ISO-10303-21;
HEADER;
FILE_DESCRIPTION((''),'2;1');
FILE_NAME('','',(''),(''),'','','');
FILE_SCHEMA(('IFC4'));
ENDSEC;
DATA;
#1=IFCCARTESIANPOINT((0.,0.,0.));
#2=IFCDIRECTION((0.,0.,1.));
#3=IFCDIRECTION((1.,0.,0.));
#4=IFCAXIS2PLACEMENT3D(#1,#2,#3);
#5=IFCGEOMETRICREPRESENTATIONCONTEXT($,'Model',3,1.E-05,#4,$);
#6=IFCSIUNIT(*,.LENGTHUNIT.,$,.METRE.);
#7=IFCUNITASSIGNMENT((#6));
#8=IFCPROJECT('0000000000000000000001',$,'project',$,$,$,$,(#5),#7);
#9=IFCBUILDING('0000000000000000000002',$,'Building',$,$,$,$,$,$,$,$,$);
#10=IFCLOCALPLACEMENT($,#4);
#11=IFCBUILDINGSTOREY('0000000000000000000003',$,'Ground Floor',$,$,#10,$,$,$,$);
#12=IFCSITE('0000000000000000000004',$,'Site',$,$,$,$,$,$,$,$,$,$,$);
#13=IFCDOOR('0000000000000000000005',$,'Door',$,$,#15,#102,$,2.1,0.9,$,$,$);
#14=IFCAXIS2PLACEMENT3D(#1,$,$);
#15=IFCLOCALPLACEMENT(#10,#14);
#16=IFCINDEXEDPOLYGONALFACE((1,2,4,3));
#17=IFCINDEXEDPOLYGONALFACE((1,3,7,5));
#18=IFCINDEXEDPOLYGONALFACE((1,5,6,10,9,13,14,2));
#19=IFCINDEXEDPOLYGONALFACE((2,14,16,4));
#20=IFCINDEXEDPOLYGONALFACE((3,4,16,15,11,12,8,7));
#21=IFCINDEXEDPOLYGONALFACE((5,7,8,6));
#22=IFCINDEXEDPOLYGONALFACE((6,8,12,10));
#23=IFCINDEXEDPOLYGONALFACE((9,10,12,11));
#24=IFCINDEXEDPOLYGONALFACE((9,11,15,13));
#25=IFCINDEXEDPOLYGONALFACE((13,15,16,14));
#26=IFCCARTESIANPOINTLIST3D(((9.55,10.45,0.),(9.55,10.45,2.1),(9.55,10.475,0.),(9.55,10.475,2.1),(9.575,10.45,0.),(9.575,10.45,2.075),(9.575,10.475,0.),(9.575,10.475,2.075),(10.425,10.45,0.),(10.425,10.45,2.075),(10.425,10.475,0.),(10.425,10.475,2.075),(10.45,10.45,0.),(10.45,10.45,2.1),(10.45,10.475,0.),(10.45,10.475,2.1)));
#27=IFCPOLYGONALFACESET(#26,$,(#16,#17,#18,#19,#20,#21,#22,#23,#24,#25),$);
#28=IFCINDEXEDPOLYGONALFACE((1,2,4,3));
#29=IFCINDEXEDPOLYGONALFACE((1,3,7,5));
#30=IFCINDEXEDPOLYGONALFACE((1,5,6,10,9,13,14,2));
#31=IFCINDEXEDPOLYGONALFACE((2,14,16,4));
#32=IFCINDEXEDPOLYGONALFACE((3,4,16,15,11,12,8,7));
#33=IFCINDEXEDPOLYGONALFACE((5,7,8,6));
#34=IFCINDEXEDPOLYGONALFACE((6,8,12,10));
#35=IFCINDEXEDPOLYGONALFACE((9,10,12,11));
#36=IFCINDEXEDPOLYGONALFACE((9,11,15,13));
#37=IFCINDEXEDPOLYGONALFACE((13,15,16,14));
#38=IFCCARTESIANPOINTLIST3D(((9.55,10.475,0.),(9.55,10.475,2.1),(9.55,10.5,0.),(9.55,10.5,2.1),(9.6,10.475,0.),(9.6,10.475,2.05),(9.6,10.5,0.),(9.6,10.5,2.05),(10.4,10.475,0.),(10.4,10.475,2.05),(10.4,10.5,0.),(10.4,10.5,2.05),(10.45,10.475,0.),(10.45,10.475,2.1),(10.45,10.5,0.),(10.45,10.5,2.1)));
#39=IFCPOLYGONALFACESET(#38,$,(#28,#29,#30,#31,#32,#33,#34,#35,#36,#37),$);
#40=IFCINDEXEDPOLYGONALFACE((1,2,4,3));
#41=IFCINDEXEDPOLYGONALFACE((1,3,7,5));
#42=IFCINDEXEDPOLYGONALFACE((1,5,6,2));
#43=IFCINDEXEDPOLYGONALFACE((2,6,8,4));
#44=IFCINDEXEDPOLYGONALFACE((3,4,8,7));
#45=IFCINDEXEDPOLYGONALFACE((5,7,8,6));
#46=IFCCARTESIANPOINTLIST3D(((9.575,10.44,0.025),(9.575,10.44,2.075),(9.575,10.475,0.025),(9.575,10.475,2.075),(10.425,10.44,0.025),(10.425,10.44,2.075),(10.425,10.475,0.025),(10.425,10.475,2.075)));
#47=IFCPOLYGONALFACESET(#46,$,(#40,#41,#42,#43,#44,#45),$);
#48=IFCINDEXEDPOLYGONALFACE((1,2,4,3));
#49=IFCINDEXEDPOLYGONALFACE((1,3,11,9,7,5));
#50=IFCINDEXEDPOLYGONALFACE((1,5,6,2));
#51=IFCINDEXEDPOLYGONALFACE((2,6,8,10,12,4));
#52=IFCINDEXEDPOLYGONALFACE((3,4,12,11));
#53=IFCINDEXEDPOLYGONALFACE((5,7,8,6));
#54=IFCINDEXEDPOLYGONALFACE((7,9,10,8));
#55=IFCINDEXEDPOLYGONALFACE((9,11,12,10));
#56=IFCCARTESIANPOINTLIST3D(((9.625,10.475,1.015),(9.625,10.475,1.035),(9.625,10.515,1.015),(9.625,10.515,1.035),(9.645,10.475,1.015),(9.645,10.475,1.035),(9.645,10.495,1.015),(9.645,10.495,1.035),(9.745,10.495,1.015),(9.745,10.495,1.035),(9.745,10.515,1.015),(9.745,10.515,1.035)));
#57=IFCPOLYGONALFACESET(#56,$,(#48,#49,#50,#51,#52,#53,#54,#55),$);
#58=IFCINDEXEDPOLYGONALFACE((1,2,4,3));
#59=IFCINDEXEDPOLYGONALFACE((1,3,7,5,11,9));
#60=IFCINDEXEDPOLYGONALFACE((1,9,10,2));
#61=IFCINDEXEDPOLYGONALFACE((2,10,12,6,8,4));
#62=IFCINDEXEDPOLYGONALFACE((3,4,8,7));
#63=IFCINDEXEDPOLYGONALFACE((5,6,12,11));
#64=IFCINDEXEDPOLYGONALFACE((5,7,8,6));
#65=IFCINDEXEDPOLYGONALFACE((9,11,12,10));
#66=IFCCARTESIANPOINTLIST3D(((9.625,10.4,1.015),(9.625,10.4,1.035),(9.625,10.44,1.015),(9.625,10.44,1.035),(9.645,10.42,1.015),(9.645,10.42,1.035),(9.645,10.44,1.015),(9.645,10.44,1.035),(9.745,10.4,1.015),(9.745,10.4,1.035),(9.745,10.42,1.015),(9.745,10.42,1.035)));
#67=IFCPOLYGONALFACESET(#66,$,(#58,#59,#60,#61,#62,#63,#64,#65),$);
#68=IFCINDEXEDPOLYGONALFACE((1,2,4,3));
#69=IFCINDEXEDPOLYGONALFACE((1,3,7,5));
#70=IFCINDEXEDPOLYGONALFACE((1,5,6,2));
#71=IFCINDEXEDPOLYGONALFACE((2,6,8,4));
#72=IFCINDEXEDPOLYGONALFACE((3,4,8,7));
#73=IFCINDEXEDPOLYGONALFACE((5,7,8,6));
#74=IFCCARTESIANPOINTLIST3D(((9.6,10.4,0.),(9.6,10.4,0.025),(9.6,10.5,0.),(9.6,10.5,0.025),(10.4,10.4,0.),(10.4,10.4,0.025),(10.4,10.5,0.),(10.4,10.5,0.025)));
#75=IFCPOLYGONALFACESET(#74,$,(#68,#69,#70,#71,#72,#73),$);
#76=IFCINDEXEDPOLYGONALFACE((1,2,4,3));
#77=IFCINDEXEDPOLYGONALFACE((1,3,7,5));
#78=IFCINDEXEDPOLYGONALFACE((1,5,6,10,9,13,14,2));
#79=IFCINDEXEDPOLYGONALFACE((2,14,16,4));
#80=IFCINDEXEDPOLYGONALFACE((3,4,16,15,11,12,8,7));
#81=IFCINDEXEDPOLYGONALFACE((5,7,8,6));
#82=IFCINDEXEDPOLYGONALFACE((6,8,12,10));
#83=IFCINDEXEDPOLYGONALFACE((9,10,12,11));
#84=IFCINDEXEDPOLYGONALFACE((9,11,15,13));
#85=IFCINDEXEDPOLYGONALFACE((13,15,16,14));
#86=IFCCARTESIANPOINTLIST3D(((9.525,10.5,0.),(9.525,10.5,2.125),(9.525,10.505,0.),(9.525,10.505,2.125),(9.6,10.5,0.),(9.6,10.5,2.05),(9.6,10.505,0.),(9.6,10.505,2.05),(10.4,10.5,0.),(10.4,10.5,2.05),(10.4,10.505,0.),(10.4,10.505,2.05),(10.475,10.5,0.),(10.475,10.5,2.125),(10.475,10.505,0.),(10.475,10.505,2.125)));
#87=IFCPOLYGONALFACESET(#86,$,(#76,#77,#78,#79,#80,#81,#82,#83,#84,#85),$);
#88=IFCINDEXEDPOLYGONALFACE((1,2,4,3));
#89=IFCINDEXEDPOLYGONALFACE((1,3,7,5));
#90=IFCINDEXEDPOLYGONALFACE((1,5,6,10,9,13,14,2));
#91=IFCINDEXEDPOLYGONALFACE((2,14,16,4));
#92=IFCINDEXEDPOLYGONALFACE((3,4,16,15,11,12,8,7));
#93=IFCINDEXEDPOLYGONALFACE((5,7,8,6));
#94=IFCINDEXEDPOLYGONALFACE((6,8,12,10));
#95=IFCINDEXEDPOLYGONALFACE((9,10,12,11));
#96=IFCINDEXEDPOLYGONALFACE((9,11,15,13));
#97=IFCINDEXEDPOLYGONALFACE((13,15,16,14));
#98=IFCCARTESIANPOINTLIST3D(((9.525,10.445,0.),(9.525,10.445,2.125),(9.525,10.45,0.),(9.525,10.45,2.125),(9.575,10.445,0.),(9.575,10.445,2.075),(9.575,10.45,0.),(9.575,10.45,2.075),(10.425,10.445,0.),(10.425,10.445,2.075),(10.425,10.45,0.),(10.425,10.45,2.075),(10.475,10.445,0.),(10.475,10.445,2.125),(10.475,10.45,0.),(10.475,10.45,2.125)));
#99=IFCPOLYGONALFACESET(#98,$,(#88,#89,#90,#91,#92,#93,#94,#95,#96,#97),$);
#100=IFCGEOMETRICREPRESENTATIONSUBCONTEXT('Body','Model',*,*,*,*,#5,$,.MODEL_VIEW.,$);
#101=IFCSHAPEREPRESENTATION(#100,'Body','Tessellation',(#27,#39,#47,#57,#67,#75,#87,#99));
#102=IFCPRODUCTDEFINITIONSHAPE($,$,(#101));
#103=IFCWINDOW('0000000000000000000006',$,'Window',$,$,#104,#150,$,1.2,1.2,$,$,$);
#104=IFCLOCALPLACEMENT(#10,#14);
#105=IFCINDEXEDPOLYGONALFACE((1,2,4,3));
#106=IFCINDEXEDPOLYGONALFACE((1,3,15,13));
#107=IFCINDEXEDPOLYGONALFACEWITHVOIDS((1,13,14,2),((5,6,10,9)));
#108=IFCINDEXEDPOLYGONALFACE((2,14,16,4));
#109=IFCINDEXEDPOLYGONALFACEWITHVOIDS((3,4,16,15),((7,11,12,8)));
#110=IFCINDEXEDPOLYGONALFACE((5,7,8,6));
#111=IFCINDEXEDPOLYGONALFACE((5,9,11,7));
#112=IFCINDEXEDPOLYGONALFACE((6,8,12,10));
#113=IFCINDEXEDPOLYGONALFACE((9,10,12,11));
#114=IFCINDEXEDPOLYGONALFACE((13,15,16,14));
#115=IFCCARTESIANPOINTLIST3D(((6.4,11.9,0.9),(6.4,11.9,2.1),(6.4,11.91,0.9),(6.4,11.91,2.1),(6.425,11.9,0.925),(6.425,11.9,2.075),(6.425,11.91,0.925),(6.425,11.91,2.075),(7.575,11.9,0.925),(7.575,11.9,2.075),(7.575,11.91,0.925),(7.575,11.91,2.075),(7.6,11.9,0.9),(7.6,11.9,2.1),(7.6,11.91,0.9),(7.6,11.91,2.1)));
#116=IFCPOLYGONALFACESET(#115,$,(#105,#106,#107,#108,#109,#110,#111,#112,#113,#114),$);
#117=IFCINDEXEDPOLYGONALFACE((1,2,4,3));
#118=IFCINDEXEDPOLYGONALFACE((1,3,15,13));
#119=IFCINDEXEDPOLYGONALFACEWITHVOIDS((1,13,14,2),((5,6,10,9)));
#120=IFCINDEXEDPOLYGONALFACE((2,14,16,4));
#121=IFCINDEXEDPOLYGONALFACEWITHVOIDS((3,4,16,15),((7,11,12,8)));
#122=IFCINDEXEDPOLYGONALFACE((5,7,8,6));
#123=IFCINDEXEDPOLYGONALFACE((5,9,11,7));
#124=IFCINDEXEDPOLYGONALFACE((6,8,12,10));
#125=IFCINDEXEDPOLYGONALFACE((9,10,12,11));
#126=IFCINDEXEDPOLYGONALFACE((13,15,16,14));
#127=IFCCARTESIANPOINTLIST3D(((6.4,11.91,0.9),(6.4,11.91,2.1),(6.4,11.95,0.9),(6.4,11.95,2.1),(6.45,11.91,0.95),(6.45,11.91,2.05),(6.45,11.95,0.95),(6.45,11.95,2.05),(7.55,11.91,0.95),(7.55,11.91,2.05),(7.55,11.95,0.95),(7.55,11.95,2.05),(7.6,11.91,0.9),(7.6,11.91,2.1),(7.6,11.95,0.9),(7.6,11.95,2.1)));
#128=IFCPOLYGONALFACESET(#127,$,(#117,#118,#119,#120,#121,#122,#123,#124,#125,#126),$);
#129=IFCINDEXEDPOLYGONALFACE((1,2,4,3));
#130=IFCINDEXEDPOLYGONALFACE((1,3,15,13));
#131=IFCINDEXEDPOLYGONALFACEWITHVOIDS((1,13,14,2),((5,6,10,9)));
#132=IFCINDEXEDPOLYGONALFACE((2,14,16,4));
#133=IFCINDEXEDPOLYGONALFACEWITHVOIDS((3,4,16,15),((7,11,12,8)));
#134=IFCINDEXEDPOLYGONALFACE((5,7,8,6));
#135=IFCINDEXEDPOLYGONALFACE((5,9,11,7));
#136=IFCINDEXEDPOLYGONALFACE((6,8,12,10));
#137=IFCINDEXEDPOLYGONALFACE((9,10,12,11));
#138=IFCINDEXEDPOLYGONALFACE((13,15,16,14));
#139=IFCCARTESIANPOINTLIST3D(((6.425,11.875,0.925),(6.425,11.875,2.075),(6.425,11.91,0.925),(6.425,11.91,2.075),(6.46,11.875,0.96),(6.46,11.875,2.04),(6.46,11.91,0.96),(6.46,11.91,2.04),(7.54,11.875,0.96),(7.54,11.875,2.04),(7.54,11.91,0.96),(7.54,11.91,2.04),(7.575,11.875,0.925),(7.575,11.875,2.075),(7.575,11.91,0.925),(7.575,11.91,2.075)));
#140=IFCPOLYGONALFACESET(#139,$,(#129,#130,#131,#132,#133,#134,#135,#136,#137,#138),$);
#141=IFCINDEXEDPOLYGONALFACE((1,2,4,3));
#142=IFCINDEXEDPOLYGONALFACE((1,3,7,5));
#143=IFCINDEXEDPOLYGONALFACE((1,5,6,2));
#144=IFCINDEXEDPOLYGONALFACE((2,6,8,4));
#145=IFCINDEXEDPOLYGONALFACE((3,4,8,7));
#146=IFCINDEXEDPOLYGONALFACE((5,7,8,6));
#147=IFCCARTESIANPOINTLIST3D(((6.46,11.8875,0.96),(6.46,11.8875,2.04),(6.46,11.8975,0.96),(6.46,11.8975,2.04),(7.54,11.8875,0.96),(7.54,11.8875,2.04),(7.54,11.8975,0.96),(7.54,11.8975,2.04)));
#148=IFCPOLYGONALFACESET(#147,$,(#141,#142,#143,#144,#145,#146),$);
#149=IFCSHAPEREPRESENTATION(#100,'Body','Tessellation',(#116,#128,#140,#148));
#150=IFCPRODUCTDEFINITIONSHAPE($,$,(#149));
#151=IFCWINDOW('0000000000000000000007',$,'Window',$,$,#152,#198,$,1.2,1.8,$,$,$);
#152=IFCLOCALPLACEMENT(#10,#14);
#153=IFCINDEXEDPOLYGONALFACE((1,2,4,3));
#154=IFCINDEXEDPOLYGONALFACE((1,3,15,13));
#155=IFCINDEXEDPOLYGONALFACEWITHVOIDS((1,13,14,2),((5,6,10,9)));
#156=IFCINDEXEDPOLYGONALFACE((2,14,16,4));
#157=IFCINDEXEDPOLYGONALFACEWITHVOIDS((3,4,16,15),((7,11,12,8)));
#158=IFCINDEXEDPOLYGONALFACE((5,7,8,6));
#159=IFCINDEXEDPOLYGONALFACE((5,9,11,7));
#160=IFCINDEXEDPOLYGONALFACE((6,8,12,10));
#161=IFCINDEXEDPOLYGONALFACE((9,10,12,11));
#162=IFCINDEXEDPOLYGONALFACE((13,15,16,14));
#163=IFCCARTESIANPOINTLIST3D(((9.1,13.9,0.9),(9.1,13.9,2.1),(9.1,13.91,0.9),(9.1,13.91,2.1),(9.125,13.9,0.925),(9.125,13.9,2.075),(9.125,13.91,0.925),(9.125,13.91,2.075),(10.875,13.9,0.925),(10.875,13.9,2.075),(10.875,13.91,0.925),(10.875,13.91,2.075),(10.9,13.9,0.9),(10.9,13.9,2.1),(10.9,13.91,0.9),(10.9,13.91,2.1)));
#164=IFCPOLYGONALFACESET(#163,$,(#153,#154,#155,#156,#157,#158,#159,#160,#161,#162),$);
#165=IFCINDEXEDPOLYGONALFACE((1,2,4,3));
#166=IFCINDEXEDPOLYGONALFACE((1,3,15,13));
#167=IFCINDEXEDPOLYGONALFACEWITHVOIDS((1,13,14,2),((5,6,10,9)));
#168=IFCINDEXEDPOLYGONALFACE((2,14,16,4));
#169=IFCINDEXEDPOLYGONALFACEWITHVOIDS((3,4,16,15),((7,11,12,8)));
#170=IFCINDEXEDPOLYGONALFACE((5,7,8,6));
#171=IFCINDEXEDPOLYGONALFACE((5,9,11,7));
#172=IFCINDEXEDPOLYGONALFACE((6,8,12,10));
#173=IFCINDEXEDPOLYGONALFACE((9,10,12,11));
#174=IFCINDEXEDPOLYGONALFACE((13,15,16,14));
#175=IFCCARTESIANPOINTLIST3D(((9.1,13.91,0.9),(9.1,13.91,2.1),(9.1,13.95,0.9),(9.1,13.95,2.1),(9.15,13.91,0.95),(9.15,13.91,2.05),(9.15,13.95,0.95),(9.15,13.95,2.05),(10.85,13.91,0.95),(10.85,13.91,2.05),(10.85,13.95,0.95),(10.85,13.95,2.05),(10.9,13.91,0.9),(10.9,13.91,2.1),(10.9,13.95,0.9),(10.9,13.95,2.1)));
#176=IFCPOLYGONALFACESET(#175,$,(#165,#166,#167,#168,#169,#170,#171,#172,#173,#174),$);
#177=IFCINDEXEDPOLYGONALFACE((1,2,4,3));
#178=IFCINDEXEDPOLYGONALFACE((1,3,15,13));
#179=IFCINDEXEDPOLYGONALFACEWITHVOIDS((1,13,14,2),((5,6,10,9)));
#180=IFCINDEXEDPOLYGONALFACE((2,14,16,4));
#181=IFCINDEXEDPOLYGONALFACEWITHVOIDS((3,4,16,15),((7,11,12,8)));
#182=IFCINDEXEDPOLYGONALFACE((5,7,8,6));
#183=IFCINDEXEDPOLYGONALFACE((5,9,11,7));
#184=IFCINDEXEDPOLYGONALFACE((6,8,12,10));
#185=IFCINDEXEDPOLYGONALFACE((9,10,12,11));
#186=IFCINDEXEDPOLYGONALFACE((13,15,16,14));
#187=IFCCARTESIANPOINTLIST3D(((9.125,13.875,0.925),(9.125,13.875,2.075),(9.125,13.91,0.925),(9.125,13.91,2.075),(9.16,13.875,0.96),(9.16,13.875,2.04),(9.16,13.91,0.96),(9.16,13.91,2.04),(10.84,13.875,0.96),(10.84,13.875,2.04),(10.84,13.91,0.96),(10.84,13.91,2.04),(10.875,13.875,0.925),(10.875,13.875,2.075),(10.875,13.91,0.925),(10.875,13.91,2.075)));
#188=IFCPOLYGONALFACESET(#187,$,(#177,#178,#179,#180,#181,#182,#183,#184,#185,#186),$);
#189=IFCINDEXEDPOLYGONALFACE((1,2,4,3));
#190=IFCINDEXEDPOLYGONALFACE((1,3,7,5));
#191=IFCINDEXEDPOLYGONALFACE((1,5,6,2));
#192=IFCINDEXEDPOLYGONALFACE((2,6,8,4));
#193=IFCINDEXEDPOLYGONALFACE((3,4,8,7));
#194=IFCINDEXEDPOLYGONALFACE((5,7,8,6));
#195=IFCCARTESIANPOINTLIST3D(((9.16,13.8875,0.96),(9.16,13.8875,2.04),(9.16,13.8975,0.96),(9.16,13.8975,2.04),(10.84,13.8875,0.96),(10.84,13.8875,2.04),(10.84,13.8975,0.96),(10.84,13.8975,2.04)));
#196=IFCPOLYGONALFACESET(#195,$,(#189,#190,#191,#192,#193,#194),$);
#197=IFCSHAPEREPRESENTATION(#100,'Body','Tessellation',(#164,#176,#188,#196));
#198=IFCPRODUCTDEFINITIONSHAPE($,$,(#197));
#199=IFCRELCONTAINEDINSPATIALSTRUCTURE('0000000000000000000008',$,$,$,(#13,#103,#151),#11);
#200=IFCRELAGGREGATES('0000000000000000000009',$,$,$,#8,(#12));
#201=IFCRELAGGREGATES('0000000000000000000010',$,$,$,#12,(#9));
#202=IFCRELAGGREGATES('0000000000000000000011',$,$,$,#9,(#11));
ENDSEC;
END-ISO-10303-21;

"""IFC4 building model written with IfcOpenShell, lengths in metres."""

from ifc_helpers import new_model, si_unit, frame, origin_with_axes, place, context, subcontext, project, spatial, line, indexed_curve, outline, extrude, element, save


model = new_model("IFC4")

# Units and contexts
model_context = context("Model", 3, precision=1e-05, world=origin_with_axes())
body_context = subcontext(model_context, "Body", "Model", "MODEL_VIEW")
ifc_project = project(units=[si_unit("LENGTHUNIT", "METRE")], contexts=[model_context])

# Site, building, storey
site = spatial("IfcSite", under=ifc_project, Name="Site")
building = spatial("IfcBuilding", under=site, Name="Building")
storey_placement = place(None, origin_with_axes())
storey = spatial("IfcBuildingStorey", under=building, at=storey_placement, Name="Ground Floor")

# Door
door_1_placement = place(storey_placement, frame((10.45, 10.5, 0.0), z_axis=(0.0, 0.0, 1.0), x_axis=(-1.0, 0.0, 0.0)))
element("IfcDoor", 1, at=door_1_placement, inside=storey, Name="Door", OverallHeight=2.1, OverallWidth=0.9, context=body_context, shape_type="SweptSolid", body=[
    extrude(outline(indexed_curve([(0.0, 0.0), (0.0, 2.1), (0.9, 2.1), (0.9, 0.0), (0.875, 0.0), (0.875, 2.075), (0.025, 2.075), (0.025, 0.0)], segments=[line(1, 2, 3, 4, 5, 6, 7, 8, 1)])), frame((0.0, 0.025, 0.0), z_axis=(0.0, -1.0, 0.0), x_axis=(1.0, 0.0, 0.0)), (0.0, 0.0, -1.0), 0.025),
    extrude(outline(indexed_curve([(0.0, 0.0), (0.0, 2.1), (0.9, 2.1), (0.9, 0.0), (0.85, 0.0), (0.85, 2.05), (0.05, 2.05), (0.05, 0.0)], segments=[line(1, 2, 3, 4, 5, 6, 7, 8, 1)])), frame((0.0, 0.0, 0.0), z_axis=(0.0, -1.0, 0.0), x_axis=(1.0, 0.0, 0.0)), (0.0, 0.0, -1.0), 0.025),
    extrude(outline(indexed_curve([(0.0, 0.0), (0.85, 0.0), (0.85, 0.035), (0.0, 0.035)], segments=[line(1, 2, 3, 4, 1)])), frame((0.025, 0.025, 0.025), z_axis=(0.0, 0.0, 1.0), x_axis=(1.0, 0.0, 0.0)), (0.0, 0.0, 1.0), 2.05),
    extrude(outline(indexed_curve([(0.0, 0.0), (0.0, -0.04), (-0.12, -0.04), (-0.12, -0.02), (-0.02, -0.02), (-0.02, 0.0)], segments=[line(1, 2, 3, 4, 5, 6, 1)])), frame((0.825, 0.025, 1.015), z_axis=(0.0, 0.0, 1.0), x_axis=(1.0, 0.0, 0.0)), (0.0, 0.0, 1.0), 0.02),
    extrude(outline(indexed_curve([(0.0, 0.0), (0.0, 0.04), (-0.12, 0.04), (-0.12, 0.02), (-0.02, 0.02), (-0.02, 0.0)], segments=[line(1, 2, 3, 4, 5, 6, 1)])), frame((0.825, 0.06, 1.015), z_axis=(0.0, 0.0, 1.0), x_axis=(1.0, 0.0, 0.0)), (0.0, 0.0, 1.0), 0.02),
    extrude(outline(indexed_curve([(0.0, 0.0), (0.8, 0.0), (0.8, 0.1), (0.0, 0.1)], segments=[line(1, 2, 3, 4, 1)])), frame((0.05, 0.0, 0.0), z_axis=(0.0, 0.0, 1.0), x_axis=(1.0, 0.0, 0.0)), (0.0, 0.0, 1.0), 0.025),
    extrude(outline(indexed_curve([(0.0, 0.0), (0.0, 2.125), (0.95, 2.125), (0.95, 0.0), (0.875, 0.0), (0.875, 2.05), (0.075, 2.05), (0.075, 0.0)], segments=[line(1, 2, 3, 4, 5, 6, 7, 8, 1)])), frame((-0.025, -0.005, 0.0), z_axis=(0.0, -1.0, 0.0), x_axis=(1.0, 0.0, 0.0)), (0.0, 0.0, -1.0), 0.005),
    extrude(outline(indexed_curve([(0.0, 0.0), (0.0, 2.125), (0.95, 2.125), (0.95, 0.0), (0.9, 0.0), (0.9, 2.075), (0.05, 2.075), (0.05, 0.0)], segments=[line(1, 2, 3, 4, 5, 6, 7, 8, 1)])), frame((-0.025, 0.05, 0.0), z_axis=(0.0, -1.0, 0.0), x_axis=(1.0, 0.0, 0.0)), (0.0, 0.0, -1.0), 0.005),
])

# Windows
window_1_placement = place(storey_placement, frame((7.6, 12.0, 0.9), z_axis=(0.0, 0.0, 1.0), x_axis=(-1.0, 0.0, 0.0)))
element("IfcWindow", 2, at=window_1_placement, inside=storey, Name="Window", OverallHeight=1.2, OverallWidth=1.2, context=body_context, shape_type="SweptSolid", body=[
    extrude(outline(indexed_curve([(0.0, 0.0), (1.2, 0.0), (1.2, 1.2), (0.0, 1.2)], segments=[line(1, 2, 3, 4, 1)]), holes=[indexed_curve([(0.025, 0.025), (1.175, 0.025), (1.175, 1.175), (0.025, 1.175)], segments=[line(1, 2, 3, 4, 1)])]), frame((0.0, 0.09, 0.0), z_axis=(0.0, -1.0, 0.0), x_axis=(1.0, 0.0, 0.0)), (0.0, 0.0, -1.0), 0.01),
    extrude(outline(indexed_curve([(0.0, 0.0), (1.2, 0.0), (1.2, 1.2), (0.0, 1.2)], segments=[line(1, 2, 3, 4, 1)]), holes=[indexed_curve([(0.05, 0.05), (1.15, 0.05), (1.15, 1.15), (0.05, 1.15)], segments=[line(1, 2, 3, 4, 1)])]), frame((0.0, 0.05, 0.0), z_axis=(0.0, -1.0, 0.0), x_axis=(1.0, 0.0, 0.0)), (0.0, 0.0, -1.0), 0.04),
    extrude(outline(indexed_curve([(0.0, 0.0), (1.15, 0.0), (1.15, 1.15), (0.0, 1.15)], segments=[line(1, 2, 3, 4, 1)]), holes=[indexed_curve([(0.035, 0.035), (1.115, 0.035), (1.115, 1.115), (0.035, 1.115)], segments=[line(1, 2, 3, 4, 1)])]), frame((0.025, 0.09, 0.025), z_axis=(0.0, -1.0, 0.0), x_axis=(1.0, 0.0, 0.0)), (0.0, 0.0, -1.0), 0.035),
    extrude(outline(indexed_curve([(0.035, 0.035), (1.115, 0.035), (1.115, 1.115), (0.035, 1.115)], segments=[line(1, 2, 3, 4, 1)])), frame((0.025, 0.1025, 0.025), z_axis=(0.0, -1.0, 0.0), x_axis=(1.0, 0.0, 0.0)), (0.0, 0.0, -1.0), 0.01),
])
window_2_placement = place(storey_placement, frame((10.9, 14.0, 0.9), z_axis=(0.0, 0.0, 1.0), x_axis=(-1.0, 0.0, 0.0)))
element("IfcWindow", 3, at=window_2_placement, inside=storey, Name="Window", OverallHeight=1.2, OverallWidth=1.8, context=body_context, shape_type="SweptSolid", body=[
    extrude(outline(indexed_curve([(0.0, 0.0), (1.8, 0.0), (1.8, 1.2), (0.0, 1.2)], segments=[line(1, 2, 3, 4, 1)]), holes=[indexed_curve([(0.025, 0.025), (1.775, 0.025), (1.775, 1.175), (0.025, 1.175)], segments=[line(1, 2, 3, 4, 1)])]), frame((0.0, 0.09, 0.0), z_axis=(0.0, -1.0, 0.0), x_axis=(1.0, 0.0, 0.0)), (0.0, 0.0, -1.0), 0.01),
    extrude(outline(indexed_curve([(0.0, 0.0), (1.8, 0.0), (1.8, 1.2), (0.0, 1.2)], segments=[line(1, 2, 3, 4, 1)]), holes=[indexed_curve([(0.05, 0.05), (1.75, 0.05), (1.75, 1.15), (0.05, 1.15)], segments=[line(1, 2, 3, 4, 1)])]), frame((0.0, 0.05, 0.0), z_axis=(0.0, -1.0, 0.0), x_axis=(1.0, 0.0, 0.0)), (0.0, 0.0, -1.0), 0.04),
    extrude(outline(indexed_curve([(0.0, 0.0), (1.75, 0.0), (1.75, 1.15), (0.0, 1.15)], segments=[line(1, 2, 3, 4, 1)]), holes=[indexed_curve([(0.035, 0.035), (1.715, 0.035), (1.715, 1.115), (0.035, 1.115)], segments=[line(1, 2, 3, 4, 1)])]), frame((0.025, 0.09, 0.025), z_axis=(0.0, -1.0, 0.0), x_axis=(1.0, 0.0, 0.0)), (0.0, 0.0, -1.0), 0.035),
    extrude(outline(indexed_curve([(0.035, 0.035), (1.715, 0.035), (1.715, 1.115), (0.035, 1.115)], segments=[line(1, 2, 3, 4, 1)])), frame((0.025, 0.1025, 0.025), z_axis=(0.0, -1.0, 0.0), x_axis=(1.0, 0.0, 0.0)), (0.0, 0.0, -1.0), 0.01),
])

save(model, "model.ifc")
